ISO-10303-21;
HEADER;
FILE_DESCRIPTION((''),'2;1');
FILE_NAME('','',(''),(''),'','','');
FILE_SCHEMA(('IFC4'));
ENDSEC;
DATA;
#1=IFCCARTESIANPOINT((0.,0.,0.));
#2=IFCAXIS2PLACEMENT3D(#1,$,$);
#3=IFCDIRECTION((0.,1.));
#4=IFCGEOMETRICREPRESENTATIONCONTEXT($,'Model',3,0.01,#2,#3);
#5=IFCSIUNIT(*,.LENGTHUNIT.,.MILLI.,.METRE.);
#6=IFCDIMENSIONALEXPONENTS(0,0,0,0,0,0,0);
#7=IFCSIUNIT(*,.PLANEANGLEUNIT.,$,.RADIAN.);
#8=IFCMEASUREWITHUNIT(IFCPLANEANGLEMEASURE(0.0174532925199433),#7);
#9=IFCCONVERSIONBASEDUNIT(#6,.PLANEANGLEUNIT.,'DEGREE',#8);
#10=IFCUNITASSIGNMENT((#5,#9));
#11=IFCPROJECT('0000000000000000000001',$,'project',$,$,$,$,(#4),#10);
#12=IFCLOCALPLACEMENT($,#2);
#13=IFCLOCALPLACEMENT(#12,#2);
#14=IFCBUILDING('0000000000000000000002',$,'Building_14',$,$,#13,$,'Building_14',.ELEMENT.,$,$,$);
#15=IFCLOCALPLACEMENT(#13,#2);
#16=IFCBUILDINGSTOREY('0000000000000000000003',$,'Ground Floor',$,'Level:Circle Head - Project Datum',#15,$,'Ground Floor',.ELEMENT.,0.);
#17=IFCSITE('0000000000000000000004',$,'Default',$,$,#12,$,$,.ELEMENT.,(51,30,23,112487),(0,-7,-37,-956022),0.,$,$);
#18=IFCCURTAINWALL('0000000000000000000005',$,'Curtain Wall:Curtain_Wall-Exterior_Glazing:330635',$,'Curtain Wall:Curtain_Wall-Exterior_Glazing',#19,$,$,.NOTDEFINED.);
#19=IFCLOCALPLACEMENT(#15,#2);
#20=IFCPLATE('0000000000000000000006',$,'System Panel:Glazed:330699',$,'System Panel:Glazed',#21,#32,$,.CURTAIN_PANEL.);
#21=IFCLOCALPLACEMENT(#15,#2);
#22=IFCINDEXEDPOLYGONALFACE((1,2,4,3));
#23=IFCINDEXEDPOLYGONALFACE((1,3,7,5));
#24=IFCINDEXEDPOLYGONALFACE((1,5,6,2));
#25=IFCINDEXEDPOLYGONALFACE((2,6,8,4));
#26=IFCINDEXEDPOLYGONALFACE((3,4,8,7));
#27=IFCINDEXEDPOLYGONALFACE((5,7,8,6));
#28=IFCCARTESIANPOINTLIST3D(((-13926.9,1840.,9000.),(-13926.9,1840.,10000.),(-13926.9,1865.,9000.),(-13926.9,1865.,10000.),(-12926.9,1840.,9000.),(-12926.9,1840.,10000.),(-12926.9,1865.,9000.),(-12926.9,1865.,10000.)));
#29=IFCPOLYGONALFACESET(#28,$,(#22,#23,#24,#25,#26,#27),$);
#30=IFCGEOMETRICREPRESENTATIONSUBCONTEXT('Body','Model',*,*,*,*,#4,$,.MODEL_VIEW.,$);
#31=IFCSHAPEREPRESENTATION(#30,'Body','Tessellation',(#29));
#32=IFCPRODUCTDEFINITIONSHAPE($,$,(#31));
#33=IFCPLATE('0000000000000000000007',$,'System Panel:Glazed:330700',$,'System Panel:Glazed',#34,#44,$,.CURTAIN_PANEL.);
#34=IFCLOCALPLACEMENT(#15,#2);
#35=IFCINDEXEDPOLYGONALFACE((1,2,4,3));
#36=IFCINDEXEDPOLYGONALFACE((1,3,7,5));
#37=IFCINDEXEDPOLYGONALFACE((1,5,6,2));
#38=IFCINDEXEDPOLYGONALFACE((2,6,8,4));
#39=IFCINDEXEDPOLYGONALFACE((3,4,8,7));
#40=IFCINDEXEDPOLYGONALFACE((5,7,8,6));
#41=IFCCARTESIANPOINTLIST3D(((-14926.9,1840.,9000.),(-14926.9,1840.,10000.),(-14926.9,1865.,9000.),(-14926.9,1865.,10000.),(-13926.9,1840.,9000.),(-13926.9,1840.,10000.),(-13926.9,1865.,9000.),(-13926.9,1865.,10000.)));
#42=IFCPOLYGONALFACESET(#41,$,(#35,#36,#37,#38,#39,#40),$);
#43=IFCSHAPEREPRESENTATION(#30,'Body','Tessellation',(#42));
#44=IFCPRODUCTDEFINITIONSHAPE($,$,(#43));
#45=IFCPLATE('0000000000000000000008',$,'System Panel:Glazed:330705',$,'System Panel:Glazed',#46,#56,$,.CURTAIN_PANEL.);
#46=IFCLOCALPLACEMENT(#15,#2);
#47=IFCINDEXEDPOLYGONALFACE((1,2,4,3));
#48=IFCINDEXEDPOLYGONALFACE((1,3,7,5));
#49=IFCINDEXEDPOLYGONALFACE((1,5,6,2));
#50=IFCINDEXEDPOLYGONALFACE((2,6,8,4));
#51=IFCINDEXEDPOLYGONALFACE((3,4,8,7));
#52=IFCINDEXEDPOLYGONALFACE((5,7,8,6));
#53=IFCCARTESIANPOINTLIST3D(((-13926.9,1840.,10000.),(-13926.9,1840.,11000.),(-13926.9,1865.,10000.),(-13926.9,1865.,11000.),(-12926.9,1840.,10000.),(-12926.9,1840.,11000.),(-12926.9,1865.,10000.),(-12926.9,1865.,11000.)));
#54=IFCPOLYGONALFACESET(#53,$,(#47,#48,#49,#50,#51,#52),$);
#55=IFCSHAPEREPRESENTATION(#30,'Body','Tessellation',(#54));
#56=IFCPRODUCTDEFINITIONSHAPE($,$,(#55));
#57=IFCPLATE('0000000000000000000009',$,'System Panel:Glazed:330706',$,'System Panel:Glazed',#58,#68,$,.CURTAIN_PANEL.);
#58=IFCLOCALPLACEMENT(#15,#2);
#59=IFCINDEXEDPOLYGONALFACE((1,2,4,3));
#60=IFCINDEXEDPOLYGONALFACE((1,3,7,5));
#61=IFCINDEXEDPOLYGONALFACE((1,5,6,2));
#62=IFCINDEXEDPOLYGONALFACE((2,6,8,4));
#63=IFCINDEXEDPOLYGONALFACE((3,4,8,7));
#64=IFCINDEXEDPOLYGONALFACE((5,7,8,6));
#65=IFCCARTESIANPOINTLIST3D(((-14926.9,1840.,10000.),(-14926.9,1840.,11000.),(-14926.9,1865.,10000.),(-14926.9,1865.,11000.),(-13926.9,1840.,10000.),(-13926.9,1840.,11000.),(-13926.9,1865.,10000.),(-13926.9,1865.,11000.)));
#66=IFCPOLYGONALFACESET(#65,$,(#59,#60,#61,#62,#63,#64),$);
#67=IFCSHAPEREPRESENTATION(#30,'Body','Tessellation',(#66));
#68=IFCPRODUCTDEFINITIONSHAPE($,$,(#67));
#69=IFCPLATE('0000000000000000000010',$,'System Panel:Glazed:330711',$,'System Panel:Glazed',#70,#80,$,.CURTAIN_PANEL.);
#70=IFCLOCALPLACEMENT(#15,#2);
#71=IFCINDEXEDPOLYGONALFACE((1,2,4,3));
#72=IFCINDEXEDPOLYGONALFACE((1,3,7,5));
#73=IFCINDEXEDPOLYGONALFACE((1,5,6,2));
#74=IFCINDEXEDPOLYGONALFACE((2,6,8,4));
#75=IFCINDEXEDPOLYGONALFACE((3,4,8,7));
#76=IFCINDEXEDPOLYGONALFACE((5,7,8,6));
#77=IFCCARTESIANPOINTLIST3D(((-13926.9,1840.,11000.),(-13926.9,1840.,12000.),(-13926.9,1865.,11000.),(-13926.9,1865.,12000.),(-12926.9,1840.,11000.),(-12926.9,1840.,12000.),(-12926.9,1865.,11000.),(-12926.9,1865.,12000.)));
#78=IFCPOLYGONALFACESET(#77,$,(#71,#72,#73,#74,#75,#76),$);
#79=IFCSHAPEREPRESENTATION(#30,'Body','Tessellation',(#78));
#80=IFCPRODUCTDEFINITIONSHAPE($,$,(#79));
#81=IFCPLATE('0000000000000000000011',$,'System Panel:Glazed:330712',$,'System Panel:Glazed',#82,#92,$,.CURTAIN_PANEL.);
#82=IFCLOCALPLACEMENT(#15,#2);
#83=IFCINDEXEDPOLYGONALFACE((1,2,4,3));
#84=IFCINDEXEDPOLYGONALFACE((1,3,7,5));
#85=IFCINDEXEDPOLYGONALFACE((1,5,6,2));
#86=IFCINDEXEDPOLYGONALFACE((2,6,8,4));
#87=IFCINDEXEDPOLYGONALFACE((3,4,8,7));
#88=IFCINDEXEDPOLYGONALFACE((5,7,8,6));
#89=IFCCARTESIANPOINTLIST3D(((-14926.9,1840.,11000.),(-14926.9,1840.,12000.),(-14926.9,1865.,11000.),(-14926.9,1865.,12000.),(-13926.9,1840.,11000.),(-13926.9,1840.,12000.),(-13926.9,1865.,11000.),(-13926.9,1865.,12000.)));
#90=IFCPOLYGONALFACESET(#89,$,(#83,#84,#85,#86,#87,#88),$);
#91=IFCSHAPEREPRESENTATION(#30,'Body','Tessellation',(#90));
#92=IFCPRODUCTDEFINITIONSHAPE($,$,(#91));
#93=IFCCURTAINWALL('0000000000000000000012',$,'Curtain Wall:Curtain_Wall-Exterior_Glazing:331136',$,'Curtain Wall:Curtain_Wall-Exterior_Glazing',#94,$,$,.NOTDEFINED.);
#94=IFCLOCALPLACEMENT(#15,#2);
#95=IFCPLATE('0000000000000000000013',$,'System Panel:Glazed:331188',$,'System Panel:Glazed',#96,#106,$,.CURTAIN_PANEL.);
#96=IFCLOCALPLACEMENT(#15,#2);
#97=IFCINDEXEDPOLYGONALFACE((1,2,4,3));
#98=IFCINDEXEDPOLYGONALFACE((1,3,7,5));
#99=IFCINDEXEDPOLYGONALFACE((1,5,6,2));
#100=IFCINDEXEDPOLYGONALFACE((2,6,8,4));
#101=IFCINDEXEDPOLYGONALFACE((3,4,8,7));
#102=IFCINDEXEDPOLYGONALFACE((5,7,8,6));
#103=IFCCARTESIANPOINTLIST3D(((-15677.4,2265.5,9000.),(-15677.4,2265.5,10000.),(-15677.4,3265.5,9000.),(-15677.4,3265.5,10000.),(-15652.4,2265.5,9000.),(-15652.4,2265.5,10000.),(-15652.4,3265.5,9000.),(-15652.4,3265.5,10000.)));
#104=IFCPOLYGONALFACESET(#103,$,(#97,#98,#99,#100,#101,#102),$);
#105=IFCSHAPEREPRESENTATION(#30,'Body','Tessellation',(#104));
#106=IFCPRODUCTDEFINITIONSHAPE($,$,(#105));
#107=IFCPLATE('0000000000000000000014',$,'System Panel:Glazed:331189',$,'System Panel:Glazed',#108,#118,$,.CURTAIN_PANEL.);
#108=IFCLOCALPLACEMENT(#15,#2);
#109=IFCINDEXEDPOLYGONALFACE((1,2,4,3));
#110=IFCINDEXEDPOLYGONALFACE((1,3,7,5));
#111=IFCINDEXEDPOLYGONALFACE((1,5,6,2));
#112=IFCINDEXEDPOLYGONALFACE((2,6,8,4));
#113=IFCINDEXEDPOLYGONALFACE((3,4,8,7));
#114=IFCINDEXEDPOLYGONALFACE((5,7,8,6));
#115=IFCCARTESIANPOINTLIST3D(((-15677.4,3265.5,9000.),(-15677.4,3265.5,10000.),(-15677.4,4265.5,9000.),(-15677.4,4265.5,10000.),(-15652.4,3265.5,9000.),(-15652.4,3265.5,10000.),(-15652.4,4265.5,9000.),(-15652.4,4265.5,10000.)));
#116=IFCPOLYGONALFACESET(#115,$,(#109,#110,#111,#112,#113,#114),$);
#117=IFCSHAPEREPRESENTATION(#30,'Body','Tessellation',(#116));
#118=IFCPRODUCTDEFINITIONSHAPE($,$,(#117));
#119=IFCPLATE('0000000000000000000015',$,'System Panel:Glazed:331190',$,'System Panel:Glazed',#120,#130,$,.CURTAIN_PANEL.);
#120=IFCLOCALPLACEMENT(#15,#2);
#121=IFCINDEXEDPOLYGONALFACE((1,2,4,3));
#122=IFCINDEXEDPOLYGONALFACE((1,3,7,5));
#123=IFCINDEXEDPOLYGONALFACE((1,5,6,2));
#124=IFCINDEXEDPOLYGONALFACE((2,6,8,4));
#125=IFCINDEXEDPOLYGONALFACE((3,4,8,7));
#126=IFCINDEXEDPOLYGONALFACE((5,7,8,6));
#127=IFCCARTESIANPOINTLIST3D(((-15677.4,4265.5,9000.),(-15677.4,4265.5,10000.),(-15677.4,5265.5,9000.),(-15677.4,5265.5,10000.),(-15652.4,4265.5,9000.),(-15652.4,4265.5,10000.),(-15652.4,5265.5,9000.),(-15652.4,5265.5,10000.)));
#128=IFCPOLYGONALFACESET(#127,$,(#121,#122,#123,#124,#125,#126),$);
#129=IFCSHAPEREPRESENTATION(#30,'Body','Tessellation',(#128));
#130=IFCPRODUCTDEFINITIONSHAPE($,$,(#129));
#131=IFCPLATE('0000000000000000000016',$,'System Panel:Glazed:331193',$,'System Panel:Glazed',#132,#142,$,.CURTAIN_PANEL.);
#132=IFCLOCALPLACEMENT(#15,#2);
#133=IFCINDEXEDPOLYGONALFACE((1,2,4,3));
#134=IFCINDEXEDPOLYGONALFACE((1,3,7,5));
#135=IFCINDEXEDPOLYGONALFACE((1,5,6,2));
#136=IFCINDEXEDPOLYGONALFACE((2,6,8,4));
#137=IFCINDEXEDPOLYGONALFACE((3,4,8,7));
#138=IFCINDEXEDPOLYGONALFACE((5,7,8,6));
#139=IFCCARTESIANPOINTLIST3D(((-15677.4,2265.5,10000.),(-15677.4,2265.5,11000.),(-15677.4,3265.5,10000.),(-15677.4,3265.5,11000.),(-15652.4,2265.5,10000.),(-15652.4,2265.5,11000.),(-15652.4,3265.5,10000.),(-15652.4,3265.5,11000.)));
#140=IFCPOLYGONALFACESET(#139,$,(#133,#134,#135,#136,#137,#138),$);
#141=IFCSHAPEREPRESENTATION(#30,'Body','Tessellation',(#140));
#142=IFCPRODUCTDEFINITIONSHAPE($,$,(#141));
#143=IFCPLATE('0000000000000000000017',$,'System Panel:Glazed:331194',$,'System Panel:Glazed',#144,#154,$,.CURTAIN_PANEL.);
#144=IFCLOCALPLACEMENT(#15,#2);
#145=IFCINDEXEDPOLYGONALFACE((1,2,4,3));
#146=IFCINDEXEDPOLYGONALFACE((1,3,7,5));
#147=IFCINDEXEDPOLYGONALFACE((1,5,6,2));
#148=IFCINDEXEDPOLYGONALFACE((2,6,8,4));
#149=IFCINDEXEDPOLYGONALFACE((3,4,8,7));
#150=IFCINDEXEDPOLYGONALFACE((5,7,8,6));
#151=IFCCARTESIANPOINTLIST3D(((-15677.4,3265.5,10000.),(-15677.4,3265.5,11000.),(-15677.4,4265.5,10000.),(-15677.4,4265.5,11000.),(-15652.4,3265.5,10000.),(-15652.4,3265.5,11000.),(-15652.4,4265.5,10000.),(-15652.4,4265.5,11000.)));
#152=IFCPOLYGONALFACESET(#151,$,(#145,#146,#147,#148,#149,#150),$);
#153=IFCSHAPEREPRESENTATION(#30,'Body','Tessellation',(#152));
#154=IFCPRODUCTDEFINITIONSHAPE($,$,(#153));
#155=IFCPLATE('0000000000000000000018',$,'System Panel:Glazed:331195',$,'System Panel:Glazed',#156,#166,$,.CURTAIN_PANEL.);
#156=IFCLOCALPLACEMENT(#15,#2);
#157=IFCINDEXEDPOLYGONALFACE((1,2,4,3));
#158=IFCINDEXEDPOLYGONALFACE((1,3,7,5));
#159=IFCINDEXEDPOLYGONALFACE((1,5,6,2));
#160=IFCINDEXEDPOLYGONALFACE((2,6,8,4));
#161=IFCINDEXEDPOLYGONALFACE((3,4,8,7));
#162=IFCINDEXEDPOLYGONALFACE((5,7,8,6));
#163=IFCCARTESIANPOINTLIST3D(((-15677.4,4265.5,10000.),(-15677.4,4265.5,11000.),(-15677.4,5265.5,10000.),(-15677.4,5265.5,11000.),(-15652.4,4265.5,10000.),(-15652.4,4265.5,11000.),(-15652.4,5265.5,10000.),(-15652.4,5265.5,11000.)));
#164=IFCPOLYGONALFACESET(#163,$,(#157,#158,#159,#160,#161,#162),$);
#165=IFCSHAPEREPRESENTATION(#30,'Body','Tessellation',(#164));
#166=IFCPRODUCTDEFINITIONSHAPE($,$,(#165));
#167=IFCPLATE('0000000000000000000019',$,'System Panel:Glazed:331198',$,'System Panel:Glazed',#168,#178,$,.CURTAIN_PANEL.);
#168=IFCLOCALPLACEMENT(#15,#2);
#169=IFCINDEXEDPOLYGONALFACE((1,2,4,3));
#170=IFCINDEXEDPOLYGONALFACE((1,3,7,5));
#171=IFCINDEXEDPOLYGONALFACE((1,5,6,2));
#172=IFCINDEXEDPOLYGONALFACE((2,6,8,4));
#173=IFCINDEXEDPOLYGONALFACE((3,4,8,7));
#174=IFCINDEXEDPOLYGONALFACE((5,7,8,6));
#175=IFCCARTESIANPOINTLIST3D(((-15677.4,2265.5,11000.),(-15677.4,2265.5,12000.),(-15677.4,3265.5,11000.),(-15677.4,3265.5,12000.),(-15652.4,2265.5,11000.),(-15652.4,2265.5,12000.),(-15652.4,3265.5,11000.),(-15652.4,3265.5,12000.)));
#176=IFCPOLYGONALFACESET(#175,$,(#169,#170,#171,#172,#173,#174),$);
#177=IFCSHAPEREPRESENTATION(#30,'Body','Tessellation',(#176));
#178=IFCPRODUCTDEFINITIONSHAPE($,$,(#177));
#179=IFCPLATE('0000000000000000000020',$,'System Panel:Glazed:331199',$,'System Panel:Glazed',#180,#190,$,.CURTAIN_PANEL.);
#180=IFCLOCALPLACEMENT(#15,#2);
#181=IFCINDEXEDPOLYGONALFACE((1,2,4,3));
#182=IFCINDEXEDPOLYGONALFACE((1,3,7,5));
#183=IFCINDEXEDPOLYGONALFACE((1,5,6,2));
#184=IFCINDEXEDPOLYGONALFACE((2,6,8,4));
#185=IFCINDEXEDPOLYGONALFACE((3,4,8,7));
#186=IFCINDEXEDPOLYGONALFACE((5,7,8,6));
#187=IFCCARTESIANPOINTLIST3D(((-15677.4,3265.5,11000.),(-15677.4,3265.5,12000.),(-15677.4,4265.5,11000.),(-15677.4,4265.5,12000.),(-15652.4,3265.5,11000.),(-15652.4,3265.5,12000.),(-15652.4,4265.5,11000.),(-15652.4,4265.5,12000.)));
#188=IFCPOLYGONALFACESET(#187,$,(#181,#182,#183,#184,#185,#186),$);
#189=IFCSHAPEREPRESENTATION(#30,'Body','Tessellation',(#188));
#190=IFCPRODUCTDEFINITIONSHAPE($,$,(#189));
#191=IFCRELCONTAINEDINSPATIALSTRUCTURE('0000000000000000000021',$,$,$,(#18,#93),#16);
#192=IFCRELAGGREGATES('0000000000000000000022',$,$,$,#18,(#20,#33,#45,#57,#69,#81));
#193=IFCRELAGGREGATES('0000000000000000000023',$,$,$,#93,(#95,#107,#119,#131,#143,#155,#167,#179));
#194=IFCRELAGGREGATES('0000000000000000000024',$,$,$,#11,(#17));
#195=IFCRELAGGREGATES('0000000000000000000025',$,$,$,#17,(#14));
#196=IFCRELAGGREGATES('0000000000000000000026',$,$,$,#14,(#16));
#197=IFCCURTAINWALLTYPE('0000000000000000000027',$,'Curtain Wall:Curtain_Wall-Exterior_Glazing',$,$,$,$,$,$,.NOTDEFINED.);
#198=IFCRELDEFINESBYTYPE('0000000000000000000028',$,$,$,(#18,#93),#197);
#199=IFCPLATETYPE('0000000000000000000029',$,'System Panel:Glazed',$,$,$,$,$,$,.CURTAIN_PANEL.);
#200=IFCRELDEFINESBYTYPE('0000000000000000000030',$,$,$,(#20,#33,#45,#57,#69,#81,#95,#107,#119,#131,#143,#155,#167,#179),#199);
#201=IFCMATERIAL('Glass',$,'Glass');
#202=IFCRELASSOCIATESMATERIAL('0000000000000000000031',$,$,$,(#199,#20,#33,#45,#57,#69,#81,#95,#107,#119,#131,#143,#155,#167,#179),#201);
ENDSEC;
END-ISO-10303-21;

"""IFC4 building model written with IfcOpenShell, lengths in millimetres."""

from ifc_helpers import new_model, entity, si_unit, converted_unit, direction, frame, origin, place, context, subcontext, project, spatial, indexed_curve, outline, extrude, source, transform, mapped, material, type_object, type_shapes, element, aggregate, save


model = new_model("IFC4")

# Units and contexts
model_context = context("Model", 3, precision=0.01, world=origin(), true_north=direction((0.0, 1.0)))
body_context = subcontext(model_context, "Body", "Model", "MODEL_VIEW")
ifc_project = project(units=[si_unit("LENGTHUNIT", "METRE", prefix="MILLI"), converted_unit("PLANEANGLEUNIT", "DEGREE", entity("IfcPlaneAngleMeasure", 0.0174532925199433), si_unit("PLANEANGLEUNIT", "RADIAN"), dimensions=[0, 0, 0, 0, 0, 0, 0])], contexts=[model_context])

# Site, building, storey
site_placement = place(None, origin())
site = spatial("IfcSite", under=ifc_project, at=site_placement, Name="Default", CompositionType="ELEMENT", RefLatitude=(51, 30, 23, 112487), RefLongitude=(0, -7, -37, -956022), RefElevation=0.0)
building_placement = place(site_placement, origin())
building = spatial("IfcBuilding", under=site, at=building_placement, Name="Building_14", LongName="Building_14", CompositionType="ELEMENT")
storey_placement = place(building_placement, origin())
storey = spatial("IfcBuildingStorey", under=building, at=storey_placement, Name="Ground Floor", ObjectType="Level:Circle Head - Project Datum", LongName="Ground Floor", CompositionType="ELEMENT", Elevation=0.0)

# Curtain walls, plates
curtain_wall_type = type_object("IfcCurtainWallType", Name="Curtain Wall:Curtain_Wall-Exterior_Glazing", PredefinedType="NOTDEFINED")
curtain_wall_1_placement = place(storey_placement, origin())
curtain_wall_1 = element("IfcCurtainWall", 1, at=curtain_wall_1_placement, inside=storey, type_object=curtain_wall_type, Name="Curtain Wall:Curtain_Wall-Exterior_Glazing:330635", ObjectType="Curtain Wall:Curtain_Wall-Exterior_Glazing", PredefinedType="NOTDEFINED")
ifc_material = material(Name="Glass", Category="Glass")
plate_type_1 = type_object("IfcPlateType", Name="System Panel:Glazed", PredefinedType="CURTAIN_PANEL", material=ifc_material)
shared_shape_1 = source(origin(), body_context, "Body", "SweptSolid", [
    extrude(outline(indexed_curve([(-12.5, -500.0), (12.5, -500.0), (12.5, 500.0), (-12.5, 500.0), (-12.5, -500.0)], self_intersect=False)), frame((0.0, -37.0, 0.0), z_axis=(0.0, 0.0, 1.0), x_axis=(0.0, 1.0, 0.0)), (0.0, 0.0, 1.0), 1000.0),
])
type_shapes(plate_type_1, [shared_shape_1])
plate_1_placement = place(curtain_wall_1_placement, frame((-13426.9, 1815.5, 9000.0), z_axis=(0.0, 0.0, 1.0), x_axis=(-1.0, 0.0, 0.0)))
plate_1 = element("IfcPlate", 2, at=plate_1_placement, type_object=plate_type_1, material=ifc_material, Name="System Panel:Glazed:330699", ObjectType="System Panel:Glazed", PredefinedType="CURTAIN_PANEL", context=body_context, shape_type="MappedRepresentation", body=[
    mapped(shared_shape_1, transform((0.0, 0.0, 0.0), scale=1.0)),
])
plate_2_placement = place(curtain_wall_1_placement, frame((-14426.9, 1815.5, 9000.0), z_axis=(0.0, 0.0, 1.0), x_axis=(-1.0, 0.0, 0.0)))
plate_2 = element("IfcPlate", 3, at=plate_2_placement, type_object=plate_type_1, material=ifc_material, Name="System Panel:Glazed:330700", ObjectType="System Panel:Glazed", PredefinedType="CURTAIN_PANEL", context=body_context, shape_type="MappedRepresentation", body=[
    mapped(shared_shape_1, transform((0.0, 0.0, 0.0), scale=1.0)),
])
plate_3_placement = place(curtain_wall_1_placement, frame((-13426.9, 1815.5, 10000.0), z_axis=(0.0, 0.0, 1.0), x_axis=(-1.0, 0.0, 0.0)))
plate_3 = element("IfcPlate", 4, at=plate_3_placement, type_object=plate_type_1, material=ifc_material, Name="System Panel:Glazed:330705", ObjectType="System Panel:Glazed", PredefinedType="CURTAIN_PANEL", context=body_context, shape_type="MappedRepresentation", body=[
    mapped(shared_shape_1, transform((0.0, 0.0, 0.0), scale=1.0)),
])
plate_4_placement = place(curtain_wall_1_placement, frame((-14426.9, 1815.5, 10000.0), z_axis=(0.0, 0.0, 1.0), x_axis=(-1.0, 0.0, 0.0)))
plate_4 = element("IfcPlate", 5, at=plate_4_placement, type_object=plate_type_1, material=ifc_material, Name="System Panel:Glazed:330706", ObjectType="System Panel:Glazed", PredefinedType="CURTAIN_PANEL", context=body_context, shape_type="MappedRepresentation", body=[
    mapped(shared_shape_1, transform((0.0, 0.0, 0.0), scale=1.0)),
])
plate_5_placement = place(curtain_wall_1_placement, frame((-13426.9, 1815.5, 11000.0), z_axis=(0.0, 0.0, 1.0), x_axis=(-1.0, 0.0, 0.0)))
plate_5 = element("IfcPlate", 6, at=plate_5_placement, type_object=plate_type_1, material=ifc_material, Name="System Panel:Glazed:330711", ObjectType="System Panel:Glazed", PredefinedType="CURTAIN_PANEL", context=body_context, shape_type="MappedRepresentation", body=[
    mapped(shared_shape_1, transform((0.0, 0.0, 0.0), scale=1.0)),
])
plate_6_placement = place(curtain_wall_1_placement, frame((-14426.9, 1815.5, 11000.0), z_axis=(0.0, 0.0, 1.0), x_axis=(-1.0, 0.0, 0.0)))
plate_6 = element("IfcPlate", 7, at=plate_6_placement, type_object=plate_type_1, material=ifc_material, Name="System Panel:Glazed:330712", ObjectType="System Panel:Glazed", PredefinedType="CURTAIN_PANEL", context=body_context, shape_type="MappedRepresentation", body=[
    mapped(shared_shape_1, transform((0.0, 0.0, 0.0), scale=1.0)),
])
curtain_wall_2_placement = place(storey_placement, origin())
curtain_wall_2 = element("IfcCurtainWall", 8, at=curtain_wall_2_placement, inside=storey, type_object=curtain_wall_type, Name="Curtain Wall:Curtain_Wall-Exterior_Glazing:331136", ObjectType="Curtain Wall:Curtain_Wall-Exterior_Glazing", PredefinedType="NOTDEFINED")
plate_7_placement = place(curtain_wall_2_placement, frame((-15701.9, 2765.5, 9000.0), z_axis=(0.0, 0.0, 1.0), x_axis=(0.0, 1.0, 0.0)))
plate_7 = element("IfcPlate", 9, at=plate_7_placement, type_object=plate_type_1, material=ifc_material, Name="System Panel:Glazed:331188", ObjectType="System Panel:Glazed", PredefinedType="CURTAIN_PANEL", context=body_context, shape_type="MappedRepresentation", body=[
    mapped(shared_shape_1, transform((0.0, 0.0, 0.0), scale=1.0)),
])
plate_8_placement = place(curtain_wall_2_placement, frame((-15701.9, 3765.5, 9000.0), z_axis=(0.0, 0.0, 1.0), x_axis=(0.0, 1.0, 0.0)))
plate_8 = element("IfcPlate", 10, at=plate_8_placement, type_object=plate_type_1, material=ifc_material, Name="System Panel:Glazed:331189", ObjectType="System Panel:Glazed", PredefinedType="CURTAIN_PANEL", context=body_context, shape_type="MappedRepresentation", body=[
    mapped(shared_shape_1, transform((0.0, 0.0, 0.0), scale=1.0)),
])
plate_9_placement = place(curtain_wall_2_placement, frame((-15701.9, 4765.5, 9000.0), z_axis=(0.0, 0.0, 1.0), x_axis=(0.0, 1.0, 0.0)))
plate_9 = element("IfcPlate", 11, at=plate_9_placement, type_object=plate_type_1, material=ifc_material, Name="System Panel:Glazed:331190", ObjectType="System Panel:Glazed", PredefinedType="CURTAIN_PANEL", context=body_context, shape_type="MappedRepresentation", body=[
    mapped(shared_shape_1, transform((0.0, 0.0, 0.0), scale=1.0)),
])
plate_10_placement = place(curtain_wall_2_placement, frame((-15701.9, 2765.5, 10000.0), z_axis=(0.0, 0.0, 1.0), x_axis=(0.0, 1.0, 0.0)))
plate_10 = element("IfcPlate", 12, at=plate_10_placement, type_object=plate_type_1, material=ifc_material, Name="System Panel:Glazed:331193", ObjectType="System Panel:Glazed", PredefinedType="CURTAIN_PANEL", context=body_context, shape_type="MappedRepresentation", body=[
    mapped(shared_shape_1, transform((0.0, 0.0, 0.0), scale=1.0)),
])
plate_11_placement = place(curtain_wall_2_placement, frame((-15701.9, 3765.5, 10000.0), z_axis=(0.0, 0.0, 1.0), x_axis=(0.0, 1.0, 0.0)))
plate_11 = element("IfcPlate", 13, at=plate_11_placement, type_object=plate_type_1, material=ifc_material, Name="System Panel:Glazed:331194", ObjectType="System Panel:Glazed", PredefinedType="CURTAIN_PANEL", context=body_context, shape_type="MappedRepresentation", body=[
    mapped(shared_shape_1, transform((0.0, 0.0, 0.0), scale=1.0)),
])
plate_12_placement = place(curtain_wall_2_placement, frame((-15701.9, 4765.5, 10000.0), z_axis=(0.0, 0.0, 1.0), x_axis=(0.0, 1.0, 0.0)))
plate_12 = element("IfcPlate", 14, at=plate_12_placement, type_object=plate_type_1, material=ifc_material, Name="System Panel:Glazed:331195", ObjectType="System Panel:Glazed", PredefinedType="CURTAIN_PANEL", context=body_context, shape_type="MappedRepresentation", body=[
    mapped(shared_shape_1, transform((0.0, 0.0, 0.0), scale=1.0)),
])
plate_13_placement = place(curtain_wall_2_placement, frame((-15701.9, 2765.5, 11000.0), z_axis=(0.0, 0.0, 1.0), x_axis=(0.0, 1.0, 0.0)))
plate_13 = element("IfcPlate", 15, at=plate_13_placement, type_object=plate_type_1, material=ifc_material, Name="System Panel:Glazed:331198", ObjectType="System Panel:Glazed", PredefinedType="CURTAIN_PANEL", context=body_context, shape_type="MappedRepresentation", body=[
    mapped(shared_shape_1, transform((0.0, 0.0, 0.0), scale=1.0)),
])
plate_14_placement = place(curtain_wall_2_placement, frame((-15701.9, 3765.5, 11000.0), z_axis=(0.0, 0.0, 1.0), x_axis=(0.0, 1.0, 0.0)))
plate_14 = element("IfcPlate", 16, at=plate_14_placement, type_object=plate_type_1, material=ifc_material, Name="System Panel:Glazed:331199", ObjectType="System Panel:Glazed", PredefinedType="CURTAIN_PANEL", context=body_context, shape_type="MappedRepresentation", body=[
    mapped(shared_shape_1, transform((0.0, 0.0, 0.0), scale=1.0)),
])

aggregate(curtain_wall_1, [plate_1, plate_2, plate_3, plate_4, plate_5, plate_6])
aggregate(curtain_wall_2, [plate_7, plate_8, plate_9, plate_10, plate_11, plate_12, plate_13, plate_14])

save(model, "model.ifc")
